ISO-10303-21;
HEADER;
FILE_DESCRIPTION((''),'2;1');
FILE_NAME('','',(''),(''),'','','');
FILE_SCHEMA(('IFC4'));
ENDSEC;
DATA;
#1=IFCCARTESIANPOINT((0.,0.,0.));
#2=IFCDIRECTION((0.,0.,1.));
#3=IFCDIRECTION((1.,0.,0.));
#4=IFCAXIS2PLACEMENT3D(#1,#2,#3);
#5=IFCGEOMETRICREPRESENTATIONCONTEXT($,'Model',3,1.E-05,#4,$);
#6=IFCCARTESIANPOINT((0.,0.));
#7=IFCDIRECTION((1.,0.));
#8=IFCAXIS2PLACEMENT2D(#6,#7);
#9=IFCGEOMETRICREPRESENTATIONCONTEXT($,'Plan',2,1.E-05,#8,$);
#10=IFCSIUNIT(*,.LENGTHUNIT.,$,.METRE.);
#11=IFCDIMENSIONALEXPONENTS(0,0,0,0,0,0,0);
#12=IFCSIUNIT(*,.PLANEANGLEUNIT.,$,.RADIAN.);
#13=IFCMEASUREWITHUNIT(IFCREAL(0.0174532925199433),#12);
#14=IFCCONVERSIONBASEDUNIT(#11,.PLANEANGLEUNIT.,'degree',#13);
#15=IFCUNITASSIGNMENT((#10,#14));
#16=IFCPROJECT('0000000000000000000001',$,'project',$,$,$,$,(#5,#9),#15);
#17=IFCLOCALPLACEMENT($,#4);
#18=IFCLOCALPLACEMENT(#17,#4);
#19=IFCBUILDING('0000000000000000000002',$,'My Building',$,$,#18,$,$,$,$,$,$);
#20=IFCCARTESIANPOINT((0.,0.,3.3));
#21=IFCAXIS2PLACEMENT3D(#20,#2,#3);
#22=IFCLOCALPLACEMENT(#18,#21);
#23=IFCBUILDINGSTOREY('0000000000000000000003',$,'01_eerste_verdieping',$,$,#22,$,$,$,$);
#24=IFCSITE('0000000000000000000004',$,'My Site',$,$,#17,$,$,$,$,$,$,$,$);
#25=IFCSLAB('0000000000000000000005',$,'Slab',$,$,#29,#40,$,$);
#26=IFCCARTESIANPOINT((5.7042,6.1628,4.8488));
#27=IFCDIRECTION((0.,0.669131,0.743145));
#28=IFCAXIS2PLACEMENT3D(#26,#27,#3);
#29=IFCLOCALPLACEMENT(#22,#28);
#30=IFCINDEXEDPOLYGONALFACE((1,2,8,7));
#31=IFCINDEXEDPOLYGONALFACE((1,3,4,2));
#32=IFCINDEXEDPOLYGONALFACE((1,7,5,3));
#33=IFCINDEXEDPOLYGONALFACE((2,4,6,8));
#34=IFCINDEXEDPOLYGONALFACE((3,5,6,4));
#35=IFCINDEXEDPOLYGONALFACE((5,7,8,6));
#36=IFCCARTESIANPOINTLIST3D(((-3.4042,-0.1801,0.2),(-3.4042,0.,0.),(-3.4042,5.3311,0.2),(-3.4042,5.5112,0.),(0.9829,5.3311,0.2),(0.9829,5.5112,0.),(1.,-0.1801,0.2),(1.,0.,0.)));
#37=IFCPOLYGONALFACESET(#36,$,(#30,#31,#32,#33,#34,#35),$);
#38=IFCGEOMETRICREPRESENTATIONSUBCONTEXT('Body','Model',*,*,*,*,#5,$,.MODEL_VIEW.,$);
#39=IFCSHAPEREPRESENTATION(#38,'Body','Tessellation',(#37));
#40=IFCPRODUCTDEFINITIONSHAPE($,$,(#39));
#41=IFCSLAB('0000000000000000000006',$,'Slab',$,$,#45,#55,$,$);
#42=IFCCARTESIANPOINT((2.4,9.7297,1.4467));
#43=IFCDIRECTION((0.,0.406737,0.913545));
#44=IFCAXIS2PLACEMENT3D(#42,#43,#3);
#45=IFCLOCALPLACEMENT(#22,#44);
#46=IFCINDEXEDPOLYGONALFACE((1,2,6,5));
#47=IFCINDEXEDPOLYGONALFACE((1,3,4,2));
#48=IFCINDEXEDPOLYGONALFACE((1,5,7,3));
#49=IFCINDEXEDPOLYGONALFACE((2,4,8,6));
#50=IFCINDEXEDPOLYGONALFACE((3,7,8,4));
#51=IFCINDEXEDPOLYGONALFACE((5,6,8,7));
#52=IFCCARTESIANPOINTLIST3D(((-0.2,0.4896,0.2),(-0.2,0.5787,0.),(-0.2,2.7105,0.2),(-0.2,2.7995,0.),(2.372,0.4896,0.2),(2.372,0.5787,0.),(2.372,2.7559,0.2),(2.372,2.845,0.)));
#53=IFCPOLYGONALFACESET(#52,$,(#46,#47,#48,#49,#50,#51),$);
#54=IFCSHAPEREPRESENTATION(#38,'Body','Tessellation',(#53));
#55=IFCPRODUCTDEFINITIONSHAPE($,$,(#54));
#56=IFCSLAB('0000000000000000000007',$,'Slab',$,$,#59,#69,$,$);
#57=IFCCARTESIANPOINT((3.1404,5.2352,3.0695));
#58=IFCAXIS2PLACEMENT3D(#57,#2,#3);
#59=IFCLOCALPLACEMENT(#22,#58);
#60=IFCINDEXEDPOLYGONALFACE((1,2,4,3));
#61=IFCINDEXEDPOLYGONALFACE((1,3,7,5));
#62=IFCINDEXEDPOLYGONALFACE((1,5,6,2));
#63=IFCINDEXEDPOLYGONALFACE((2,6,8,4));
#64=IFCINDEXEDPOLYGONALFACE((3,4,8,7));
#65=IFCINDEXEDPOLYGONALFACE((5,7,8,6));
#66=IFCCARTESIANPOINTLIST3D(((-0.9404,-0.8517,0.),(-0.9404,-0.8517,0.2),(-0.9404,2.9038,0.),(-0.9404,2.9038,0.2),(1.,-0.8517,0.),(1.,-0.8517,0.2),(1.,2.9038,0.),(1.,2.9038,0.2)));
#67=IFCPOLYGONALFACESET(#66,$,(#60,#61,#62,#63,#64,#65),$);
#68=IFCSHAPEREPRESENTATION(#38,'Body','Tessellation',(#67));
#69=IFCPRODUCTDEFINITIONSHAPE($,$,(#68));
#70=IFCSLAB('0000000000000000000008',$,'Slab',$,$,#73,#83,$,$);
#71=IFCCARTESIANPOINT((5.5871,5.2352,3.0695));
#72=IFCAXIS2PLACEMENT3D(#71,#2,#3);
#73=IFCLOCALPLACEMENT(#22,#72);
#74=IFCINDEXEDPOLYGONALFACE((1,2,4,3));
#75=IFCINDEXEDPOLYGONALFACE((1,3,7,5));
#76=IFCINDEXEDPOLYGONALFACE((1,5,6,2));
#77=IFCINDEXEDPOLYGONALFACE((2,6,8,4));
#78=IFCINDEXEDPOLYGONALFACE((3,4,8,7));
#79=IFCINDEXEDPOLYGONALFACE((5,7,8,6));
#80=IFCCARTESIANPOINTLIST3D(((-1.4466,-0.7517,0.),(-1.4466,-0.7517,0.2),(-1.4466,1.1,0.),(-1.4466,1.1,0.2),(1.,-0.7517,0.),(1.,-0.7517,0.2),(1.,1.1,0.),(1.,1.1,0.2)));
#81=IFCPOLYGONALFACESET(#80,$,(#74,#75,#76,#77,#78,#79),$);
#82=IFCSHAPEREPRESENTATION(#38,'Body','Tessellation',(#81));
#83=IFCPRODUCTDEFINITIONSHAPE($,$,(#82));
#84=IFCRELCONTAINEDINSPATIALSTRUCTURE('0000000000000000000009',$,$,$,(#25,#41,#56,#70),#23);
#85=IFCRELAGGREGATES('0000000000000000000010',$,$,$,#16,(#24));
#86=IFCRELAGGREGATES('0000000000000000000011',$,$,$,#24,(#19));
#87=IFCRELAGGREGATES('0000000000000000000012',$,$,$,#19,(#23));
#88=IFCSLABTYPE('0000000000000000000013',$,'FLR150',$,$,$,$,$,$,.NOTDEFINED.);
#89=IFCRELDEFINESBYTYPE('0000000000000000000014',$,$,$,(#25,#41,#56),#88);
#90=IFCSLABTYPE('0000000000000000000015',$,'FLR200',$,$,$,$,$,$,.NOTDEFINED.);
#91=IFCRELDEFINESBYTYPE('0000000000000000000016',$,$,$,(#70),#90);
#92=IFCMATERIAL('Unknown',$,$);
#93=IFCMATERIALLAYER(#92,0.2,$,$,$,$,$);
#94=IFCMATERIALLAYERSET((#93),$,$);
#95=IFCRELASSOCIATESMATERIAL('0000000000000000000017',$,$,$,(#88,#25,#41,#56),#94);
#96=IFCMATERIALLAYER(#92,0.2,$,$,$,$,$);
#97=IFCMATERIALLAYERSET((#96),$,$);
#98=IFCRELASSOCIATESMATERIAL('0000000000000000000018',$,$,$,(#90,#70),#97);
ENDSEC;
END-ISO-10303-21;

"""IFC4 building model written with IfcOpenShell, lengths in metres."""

from ifc_helpers import new_model, entity, si_unit, converted_unit, frame, origin_with_axes, origin_2d_with_axis, place, context, subcontext, project, spatial, line, indexed_curve, outline, extrude, material, layer, layer_set, layer_usage, type_object, element, save


model = new_model("IFC4")

# Units and contexts
model_context = context("Model", 3, precision=1e-05, world=origin_with_axes())
plan_context = context("Plan", 2, precision=1e-05, world=origin_2d_with_axis())
body_context_1 = subcontext(model_context, "Body", "Model", "MODEL_VIEW")
ifc_project = project(units=[si_unit("LENGTHUNIT", "METRE"), converted_unit("PLANEANGLEUNIT", "degree", entity("IfcReal", 0.0174532925199433), si_unit("PLANEANGLEUNIT", "RADIAN"), dimensions=[0, 0, 0, 0, 0, 0, 0])], contexts=[model_context, plan_context])

# Site, building, storey
site_placement = place(None, origin_with_axes())
site = spatial("IfcSite", under=ifc_project, at=site_placement, Name="My Site")
building_placement = place(site_placement, origin_with_axes())
building = spatial("IfcBuilding", under=site, at=building_placement, Name="My Building")
storey_placement = place(building_placement, frame((0.0, 0.0, 3.3), z_axis=(0.0, 0.0, 1.0), x_axis=(1.0, 0.0, 0.0)))
storey = spatial("IfcBuildingStorey", under=building, at=storey_placement, Name="01_eerste_verdieping")

# Shared definitions
ifc_material_1 = material(Name="Unknown")

# Slabs
ifc_layer_1 = layer(ifc_material_1, 0.2)
ifc_layer_set_1 = layer_set([ifc_layer_1])
slab_type_1 = type_object("IfcSlabType", Name="FLR150", PredefinedType="NOTDEFINED", material=ifc_layer_set_1)
ifc_layer_usage_1 = layer_usage(ifc_layer_set_1, "AXIS3", "POSITIVE", 0.0)
slab_1_placement = place(storey_placement, frame((5.7042, 6.1628, 4.8488), z_axis=(0.0, 0.669131, 0.743145), x_axis=(1.0, 0.0, 0.0)))
element("IfcSlab", 1, at=slab_1_placement, inside=storey, type_object=slab_type_1, material=ifc_layer_usage_1, Name="Slab", context=body_context_1, shape_type="SweptSolid", body=[
    extrude(outline(indexed_curve([(1.0, 0.0), (-3.4042, 0.0), (-3.4042, 5.5112), (0.9829, 5.5112)], segments=[line(4, 1), line(1, 2), line(2, 3), line(3, 4)], self_intersect=False)), None, (0.0, -0.669131, 0.743145), 0.2691),
])
ifc_layer_usage_2 = layer_usage(ifc_layer_set_1, "AXIS3", "POSITIVE", 0.0)
slab_2_placement = place(storey_placement, frame((2.4, 9.7297, 1.4467), z_axis=(0.0, 0.406737, 0.913545), x_axis=(1.0, 0.0, 0.0)))
element("IfcSlab", 2, at=slab_2_placement, inside=storey, type_object=slab_type_1, material=ifc_layer_usage_2, Name="Slab", context=body_context_1, shape_type="SweptSolid", body=[
    extrude(outline(indexed_curve([(-0.2, 2.7995), (2.372, 2.845), (2.372, 0.5787), (-0.2, 0.5787)], segments=[line(4, 1), line(1, 2), line(2, 3), line(3, 4)], self_intersect=False)), None, (0.0, -0.406737, 0.913545), 0.2189),
])
ifc_layer_usage_3 = layer_usage(ifc_layer_set_1, "AXIS3", "POSITIVE", 0.0)
slab_3_placement = place(storey_placement, frame((3.1404, 5.2352, 3.0695), z_axis=(0.0, 0.0, 1.0), x_axis=(1.0, 0.0, 0.0)))
element("IfcSlab", 3, at=slab_3_placement, inside=storey, type_object=slab_type_1, material=ifc_layer_usage_3, Name="Slab", context=body_context_1, shape_type="SweptSolid", body=[
    extrude(outline(indexed_curve([(-0.9404, -0.8517), (1.0, -0.8517), (1.0, 2.9038), (-0.9404, 2.9038)], segments=[line(3, 2), line(2, 1), line(1, 4), line(4, 3)], self_intersect=False)), None, (0.0, 0.0, 1.0), 0.2),
])
ifc_layer_2 = layer(ifc_material_1, 0.2)
ifc_layer_set_2 = layer_set([ifc_layer_2])
ifc_layer_usage_4 = layer_usage(ifc_layer_set_2, "AXIS3", "POSITIVE", 0.0)
slab_type_2 = type_object("IfcSlabType", Name="FLR200", PredefinedType="NOTDEFINED", material=ifc_layer_set_2)
slab_4_placement = place(storey_placement, frame((5.5871, 5.2352, 3.0695), z_axis=(0.0, 0.0, 1.0), x_axis=(1.0, 0.0, 0.0)))
element("IfcSlab", 4, at=slab_4_placement, inside=storey, type_object=slab_type_2, material=ifc_layer_usage_4, Name="Slab", context=body_context_1, shape_type="SweptSolid", body=[
    extrude(outline(indexed_curve([(1.0, 1.1), (1.0, -0.7517), (-1.4466, -0.7517), (-1.4466, 1.1)], segments=[line(3, 2), line(2, 1), line(1, 4), line(4, 3)], self_intersect=False)), None, (0.0, 0.0, 1.0), 0.2),
])

save(model, "model.ifc")
